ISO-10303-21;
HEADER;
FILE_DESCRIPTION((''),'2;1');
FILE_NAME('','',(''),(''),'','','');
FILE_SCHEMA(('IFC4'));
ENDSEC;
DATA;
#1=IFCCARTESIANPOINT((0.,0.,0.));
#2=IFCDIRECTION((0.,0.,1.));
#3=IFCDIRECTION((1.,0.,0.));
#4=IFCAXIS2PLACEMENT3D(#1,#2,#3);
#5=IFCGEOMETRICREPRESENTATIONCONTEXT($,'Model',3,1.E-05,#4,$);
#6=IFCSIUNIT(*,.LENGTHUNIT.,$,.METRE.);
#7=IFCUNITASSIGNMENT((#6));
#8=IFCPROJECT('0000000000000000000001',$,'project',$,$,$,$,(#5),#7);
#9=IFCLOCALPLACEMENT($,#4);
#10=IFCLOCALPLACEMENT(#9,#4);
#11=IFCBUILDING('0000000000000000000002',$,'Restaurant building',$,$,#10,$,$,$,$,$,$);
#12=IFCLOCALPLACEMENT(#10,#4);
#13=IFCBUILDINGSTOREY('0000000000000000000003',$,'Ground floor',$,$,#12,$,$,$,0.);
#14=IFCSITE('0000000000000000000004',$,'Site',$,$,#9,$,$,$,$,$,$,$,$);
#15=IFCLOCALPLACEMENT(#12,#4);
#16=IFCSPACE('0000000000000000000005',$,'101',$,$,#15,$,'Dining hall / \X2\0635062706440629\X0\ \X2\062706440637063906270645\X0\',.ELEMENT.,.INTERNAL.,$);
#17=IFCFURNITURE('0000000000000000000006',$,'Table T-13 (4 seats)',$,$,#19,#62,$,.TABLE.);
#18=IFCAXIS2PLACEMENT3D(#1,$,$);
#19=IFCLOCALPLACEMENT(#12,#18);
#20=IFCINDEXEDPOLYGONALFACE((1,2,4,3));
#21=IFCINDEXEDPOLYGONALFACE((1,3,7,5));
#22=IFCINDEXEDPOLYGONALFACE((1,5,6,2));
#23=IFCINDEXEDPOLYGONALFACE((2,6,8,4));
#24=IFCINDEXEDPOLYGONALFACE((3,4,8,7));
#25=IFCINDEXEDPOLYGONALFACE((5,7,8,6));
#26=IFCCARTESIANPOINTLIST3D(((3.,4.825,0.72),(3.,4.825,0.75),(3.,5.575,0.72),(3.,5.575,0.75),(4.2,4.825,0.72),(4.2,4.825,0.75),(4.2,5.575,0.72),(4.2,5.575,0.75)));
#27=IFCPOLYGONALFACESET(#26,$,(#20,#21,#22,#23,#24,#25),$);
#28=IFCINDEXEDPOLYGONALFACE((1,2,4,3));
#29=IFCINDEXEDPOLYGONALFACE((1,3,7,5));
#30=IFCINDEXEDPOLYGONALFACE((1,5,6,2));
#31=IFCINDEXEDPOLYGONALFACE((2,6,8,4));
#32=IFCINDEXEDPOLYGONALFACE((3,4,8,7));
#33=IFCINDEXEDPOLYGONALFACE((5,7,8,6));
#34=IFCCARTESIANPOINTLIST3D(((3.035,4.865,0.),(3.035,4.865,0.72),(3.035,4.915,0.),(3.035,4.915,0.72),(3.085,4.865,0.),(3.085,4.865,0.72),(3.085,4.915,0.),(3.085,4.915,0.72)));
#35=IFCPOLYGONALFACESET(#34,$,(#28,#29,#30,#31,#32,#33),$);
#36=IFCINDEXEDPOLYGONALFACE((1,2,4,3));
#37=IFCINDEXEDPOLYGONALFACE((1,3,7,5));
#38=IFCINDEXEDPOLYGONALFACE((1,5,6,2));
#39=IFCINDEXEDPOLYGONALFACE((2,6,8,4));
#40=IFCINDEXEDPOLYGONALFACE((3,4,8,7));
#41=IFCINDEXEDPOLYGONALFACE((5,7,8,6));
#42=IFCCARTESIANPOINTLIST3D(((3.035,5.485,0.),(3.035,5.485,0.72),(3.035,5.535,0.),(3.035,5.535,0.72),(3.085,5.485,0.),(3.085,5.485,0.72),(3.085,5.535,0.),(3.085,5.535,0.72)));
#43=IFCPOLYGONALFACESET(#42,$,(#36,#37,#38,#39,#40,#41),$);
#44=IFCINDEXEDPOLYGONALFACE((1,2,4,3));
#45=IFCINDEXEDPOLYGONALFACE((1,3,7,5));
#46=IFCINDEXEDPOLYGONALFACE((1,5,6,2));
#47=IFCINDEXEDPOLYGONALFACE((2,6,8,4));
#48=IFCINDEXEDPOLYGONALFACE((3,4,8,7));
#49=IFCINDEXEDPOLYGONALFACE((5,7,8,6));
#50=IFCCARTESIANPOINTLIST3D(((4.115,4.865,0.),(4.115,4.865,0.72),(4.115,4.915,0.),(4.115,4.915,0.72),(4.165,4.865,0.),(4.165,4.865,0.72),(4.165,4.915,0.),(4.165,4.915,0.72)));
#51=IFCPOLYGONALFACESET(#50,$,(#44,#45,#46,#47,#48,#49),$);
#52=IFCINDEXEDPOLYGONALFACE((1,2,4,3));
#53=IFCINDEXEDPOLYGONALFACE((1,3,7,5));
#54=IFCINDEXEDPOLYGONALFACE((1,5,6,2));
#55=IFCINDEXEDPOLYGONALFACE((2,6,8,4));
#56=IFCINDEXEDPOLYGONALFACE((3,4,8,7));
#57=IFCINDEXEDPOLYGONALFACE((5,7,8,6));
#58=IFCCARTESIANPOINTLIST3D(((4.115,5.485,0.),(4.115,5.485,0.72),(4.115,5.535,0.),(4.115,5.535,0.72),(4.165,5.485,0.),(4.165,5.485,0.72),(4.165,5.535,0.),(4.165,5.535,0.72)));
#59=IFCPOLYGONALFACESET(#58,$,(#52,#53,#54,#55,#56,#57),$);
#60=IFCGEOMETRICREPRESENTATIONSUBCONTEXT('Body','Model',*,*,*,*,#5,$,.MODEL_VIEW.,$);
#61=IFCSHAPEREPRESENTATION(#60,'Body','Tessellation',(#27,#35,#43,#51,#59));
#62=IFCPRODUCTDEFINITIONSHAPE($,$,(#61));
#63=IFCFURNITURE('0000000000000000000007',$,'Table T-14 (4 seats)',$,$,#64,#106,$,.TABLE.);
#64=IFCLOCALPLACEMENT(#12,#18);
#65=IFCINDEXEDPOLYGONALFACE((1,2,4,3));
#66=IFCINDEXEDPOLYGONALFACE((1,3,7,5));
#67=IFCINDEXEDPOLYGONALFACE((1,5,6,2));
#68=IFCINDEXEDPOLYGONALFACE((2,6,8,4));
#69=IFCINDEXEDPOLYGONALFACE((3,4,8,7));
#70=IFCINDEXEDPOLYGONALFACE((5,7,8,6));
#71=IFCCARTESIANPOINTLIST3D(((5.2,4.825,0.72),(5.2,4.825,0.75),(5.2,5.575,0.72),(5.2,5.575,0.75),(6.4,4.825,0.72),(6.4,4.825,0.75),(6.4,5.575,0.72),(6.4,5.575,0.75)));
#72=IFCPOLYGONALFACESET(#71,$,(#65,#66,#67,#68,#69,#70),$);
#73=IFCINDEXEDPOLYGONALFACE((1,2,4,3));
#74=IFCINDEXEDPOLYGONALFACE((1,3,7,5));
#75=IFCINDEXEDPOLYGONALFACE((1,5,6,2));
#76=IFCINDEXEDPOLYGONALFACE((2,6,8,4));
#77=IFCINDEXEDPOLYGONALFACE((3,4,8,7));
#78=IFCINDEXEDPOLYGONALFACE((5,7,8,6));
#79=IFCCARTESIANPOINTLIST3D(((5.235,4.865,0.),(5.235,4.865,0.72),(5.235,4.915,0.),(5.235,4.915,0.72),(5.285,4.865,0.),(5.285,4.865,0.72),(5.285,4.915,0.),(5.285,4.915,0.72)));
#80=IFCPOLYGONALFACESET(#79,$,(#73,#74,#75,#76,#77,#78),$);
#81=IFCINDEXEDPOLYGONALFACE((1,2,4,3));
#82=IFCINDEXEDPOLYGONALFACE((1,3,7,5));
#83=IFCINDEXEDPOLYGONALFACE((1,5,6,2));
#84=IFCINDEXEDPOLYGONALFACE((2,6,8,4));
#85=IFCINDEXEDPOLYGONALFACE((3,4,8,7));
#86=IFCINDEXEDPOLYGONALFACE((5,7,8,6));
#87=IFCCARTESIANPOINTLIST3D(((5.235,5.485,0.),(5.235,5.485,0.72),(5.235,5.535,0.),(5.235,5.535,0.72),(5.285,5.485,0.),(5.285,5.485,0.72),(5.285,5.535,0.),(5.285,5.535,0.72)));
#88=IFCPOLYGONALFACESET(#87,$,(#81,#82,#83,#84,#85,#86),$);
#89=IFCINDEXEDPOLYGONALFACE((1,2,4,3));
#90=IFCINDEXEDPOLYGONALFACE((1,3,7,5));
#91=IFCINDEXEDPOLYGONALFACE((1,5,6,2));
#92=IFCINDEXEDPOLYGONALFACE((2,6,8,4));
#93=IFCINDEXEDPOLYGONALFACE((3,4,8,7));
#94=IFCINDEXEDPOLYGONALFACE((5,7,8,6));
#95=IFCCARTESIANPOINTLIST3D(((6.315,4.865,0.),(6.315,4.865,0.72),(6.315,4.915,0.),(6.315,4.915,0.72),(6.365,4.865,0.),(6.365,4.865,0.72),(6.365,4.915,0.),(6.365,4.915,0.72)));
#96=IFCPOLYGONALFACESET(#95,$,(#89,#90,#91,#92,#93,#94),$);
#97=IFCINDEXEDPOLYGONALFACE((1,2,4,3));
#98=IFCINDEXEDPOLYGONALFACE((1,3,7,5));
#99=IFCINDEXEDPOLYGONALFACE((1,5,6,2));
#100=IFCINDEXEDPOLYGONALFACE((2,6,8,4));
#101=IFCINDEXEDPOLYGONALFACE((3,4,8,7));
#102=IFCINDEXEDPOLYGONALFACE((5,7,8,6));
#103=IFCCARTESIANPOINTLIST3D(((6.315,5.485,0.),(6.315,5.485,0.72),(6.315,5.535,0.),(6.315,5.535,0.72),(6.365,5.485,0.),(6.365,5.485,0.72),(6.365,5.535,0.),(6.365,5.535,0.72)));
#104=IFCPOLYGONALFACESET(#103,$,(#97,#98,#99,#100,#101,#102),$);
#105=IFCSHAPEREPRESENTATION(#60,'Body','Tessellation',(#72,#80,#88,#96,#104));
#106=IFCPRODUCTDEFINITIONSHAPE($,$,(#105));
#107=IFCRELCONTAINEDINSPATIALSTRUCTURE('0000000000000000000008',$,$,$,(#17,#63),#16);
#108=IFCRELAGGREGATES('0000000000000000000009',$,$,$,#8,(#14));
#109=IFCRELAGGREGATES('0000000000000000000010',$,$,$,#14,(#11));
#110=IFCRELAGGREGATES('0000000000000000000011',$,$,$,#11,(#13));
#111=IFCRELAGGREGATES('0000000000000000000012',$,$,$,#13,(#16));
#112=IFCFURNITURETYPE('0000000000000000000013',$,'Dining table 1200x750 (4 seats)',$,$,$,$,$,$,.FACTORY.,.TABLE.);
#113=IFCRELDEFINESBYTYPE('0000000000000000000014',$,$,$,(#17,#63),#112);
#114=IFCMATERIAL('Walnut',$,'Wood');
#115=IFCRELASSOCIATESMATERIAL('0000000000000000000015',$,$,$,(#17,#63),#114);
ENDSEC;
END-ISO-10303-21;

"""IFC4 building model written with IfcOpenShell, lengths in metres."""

from ifc_helpers import new_model, si_unit, frame, origin, origin_with_axes, origin_2d, place, context, subcontext, project, spatial, rectangle, extrude, source, transform, mapped, material, type_object, type_shapes, element, save


model = new_model("IFC4")

# Units and contexts
model_context = context("Model", 3, precision=1e-05, world=origin_with_axes())
body_context = subcontext(model_context, "Body", "Model", "MODEL_VIEW")
ifc_project = project(units=[si_unit("LENGTHUNIT", "METRE")], contexts=[model_context])

# Site, building, storey, space
site_placement = place(None, origin_with_axes())
site = spatial("IfcSite", under=ifc_project, at=site_placement, Name="Site")
building_placement = place(site_placement, origin_with_axes())
building = spatial("IfcBuilding", under=site, at=building_placement, Name="Restaurant building")
storey_placement = place(building_placement, origin_with_axes())
storey = spatial("IfcBuildingStorey", under=building, at=storey_placement, Name="Ground floor", Elevation=0.0)
space_placement = place(storey_placement, origin_with_axes())
space = spatial("IfcSpace", under=storey, at=space_placement, Name="101", LongName="Dining hall / صالة الطعام", CompositionType="ELEMENT", PredefinedType="INTERNAL")

# Furniture
ifc_material_1 = material(Name="Walnut", Category="Wood")
furniture_type_1 = type_object("IfcFurnitureType", Name="Dining table 1200x750 (4 seats)", AssemblyPlace="FACTORY", PredefinedType="TABLE")
shared_shape_1 = source(origin(), body_context, "Body", "SweptSolid", [
    extrude(rectangle(XDim=1.2, YDim=0.75, at=origin_2d()), frame((0.0, 0.0, 0.72)), (0.0, 0.0, 1.0), 0.03),
    extrude(rectangle(XDim=0.05, YDim=0.05, at=origin_2d()), frame((-0.54, -0.31, 0.0)), (0.0, 0.0, 1.0), 0.72),
    extrude(rectangle(XDim=0.05, YDim=0.05, at=origin_2d()), frame((-0.54, 0.31, 0.0)), (0.0, 0.0, 1.0), 0.72),
    extrude(rectangle(XDim=0.05, YDim=0.05, at=origin_2d()), frame((0.54, -0.31, 0.0)), (0.0, 0.0, 1.0), 0.72),
    extrude(rectangle(XDim=0.05, YDim=0.05, at=origin_2d()), frame((0.54, 0.31, 0.0)), (0.0, 0.0, 1.0), 0.72),
])
type_shapes(furniture_type_1, [shared_shape_1])
for number, where, name in (
    (1, (3.6, 5.2, 0.0), "Table T-13 (4 seats)"),
    (2, (5.8, 5.2, 0.0), "Table T-14 (4 seats)"),
):
    element("IfcFurniture", number, at=place(storey_placement, frame(where)), inside=space, type_object=furniture_type_1, material=ifc_material_1, Name=name, PredefinedType="TABLE", context=body_context, shape_type="MappedRepresentation", body=[
        mapped(shared_shape_1, transform((0.0, 0.0, 0.0))),
    ])

save(model, "model.ifc")
